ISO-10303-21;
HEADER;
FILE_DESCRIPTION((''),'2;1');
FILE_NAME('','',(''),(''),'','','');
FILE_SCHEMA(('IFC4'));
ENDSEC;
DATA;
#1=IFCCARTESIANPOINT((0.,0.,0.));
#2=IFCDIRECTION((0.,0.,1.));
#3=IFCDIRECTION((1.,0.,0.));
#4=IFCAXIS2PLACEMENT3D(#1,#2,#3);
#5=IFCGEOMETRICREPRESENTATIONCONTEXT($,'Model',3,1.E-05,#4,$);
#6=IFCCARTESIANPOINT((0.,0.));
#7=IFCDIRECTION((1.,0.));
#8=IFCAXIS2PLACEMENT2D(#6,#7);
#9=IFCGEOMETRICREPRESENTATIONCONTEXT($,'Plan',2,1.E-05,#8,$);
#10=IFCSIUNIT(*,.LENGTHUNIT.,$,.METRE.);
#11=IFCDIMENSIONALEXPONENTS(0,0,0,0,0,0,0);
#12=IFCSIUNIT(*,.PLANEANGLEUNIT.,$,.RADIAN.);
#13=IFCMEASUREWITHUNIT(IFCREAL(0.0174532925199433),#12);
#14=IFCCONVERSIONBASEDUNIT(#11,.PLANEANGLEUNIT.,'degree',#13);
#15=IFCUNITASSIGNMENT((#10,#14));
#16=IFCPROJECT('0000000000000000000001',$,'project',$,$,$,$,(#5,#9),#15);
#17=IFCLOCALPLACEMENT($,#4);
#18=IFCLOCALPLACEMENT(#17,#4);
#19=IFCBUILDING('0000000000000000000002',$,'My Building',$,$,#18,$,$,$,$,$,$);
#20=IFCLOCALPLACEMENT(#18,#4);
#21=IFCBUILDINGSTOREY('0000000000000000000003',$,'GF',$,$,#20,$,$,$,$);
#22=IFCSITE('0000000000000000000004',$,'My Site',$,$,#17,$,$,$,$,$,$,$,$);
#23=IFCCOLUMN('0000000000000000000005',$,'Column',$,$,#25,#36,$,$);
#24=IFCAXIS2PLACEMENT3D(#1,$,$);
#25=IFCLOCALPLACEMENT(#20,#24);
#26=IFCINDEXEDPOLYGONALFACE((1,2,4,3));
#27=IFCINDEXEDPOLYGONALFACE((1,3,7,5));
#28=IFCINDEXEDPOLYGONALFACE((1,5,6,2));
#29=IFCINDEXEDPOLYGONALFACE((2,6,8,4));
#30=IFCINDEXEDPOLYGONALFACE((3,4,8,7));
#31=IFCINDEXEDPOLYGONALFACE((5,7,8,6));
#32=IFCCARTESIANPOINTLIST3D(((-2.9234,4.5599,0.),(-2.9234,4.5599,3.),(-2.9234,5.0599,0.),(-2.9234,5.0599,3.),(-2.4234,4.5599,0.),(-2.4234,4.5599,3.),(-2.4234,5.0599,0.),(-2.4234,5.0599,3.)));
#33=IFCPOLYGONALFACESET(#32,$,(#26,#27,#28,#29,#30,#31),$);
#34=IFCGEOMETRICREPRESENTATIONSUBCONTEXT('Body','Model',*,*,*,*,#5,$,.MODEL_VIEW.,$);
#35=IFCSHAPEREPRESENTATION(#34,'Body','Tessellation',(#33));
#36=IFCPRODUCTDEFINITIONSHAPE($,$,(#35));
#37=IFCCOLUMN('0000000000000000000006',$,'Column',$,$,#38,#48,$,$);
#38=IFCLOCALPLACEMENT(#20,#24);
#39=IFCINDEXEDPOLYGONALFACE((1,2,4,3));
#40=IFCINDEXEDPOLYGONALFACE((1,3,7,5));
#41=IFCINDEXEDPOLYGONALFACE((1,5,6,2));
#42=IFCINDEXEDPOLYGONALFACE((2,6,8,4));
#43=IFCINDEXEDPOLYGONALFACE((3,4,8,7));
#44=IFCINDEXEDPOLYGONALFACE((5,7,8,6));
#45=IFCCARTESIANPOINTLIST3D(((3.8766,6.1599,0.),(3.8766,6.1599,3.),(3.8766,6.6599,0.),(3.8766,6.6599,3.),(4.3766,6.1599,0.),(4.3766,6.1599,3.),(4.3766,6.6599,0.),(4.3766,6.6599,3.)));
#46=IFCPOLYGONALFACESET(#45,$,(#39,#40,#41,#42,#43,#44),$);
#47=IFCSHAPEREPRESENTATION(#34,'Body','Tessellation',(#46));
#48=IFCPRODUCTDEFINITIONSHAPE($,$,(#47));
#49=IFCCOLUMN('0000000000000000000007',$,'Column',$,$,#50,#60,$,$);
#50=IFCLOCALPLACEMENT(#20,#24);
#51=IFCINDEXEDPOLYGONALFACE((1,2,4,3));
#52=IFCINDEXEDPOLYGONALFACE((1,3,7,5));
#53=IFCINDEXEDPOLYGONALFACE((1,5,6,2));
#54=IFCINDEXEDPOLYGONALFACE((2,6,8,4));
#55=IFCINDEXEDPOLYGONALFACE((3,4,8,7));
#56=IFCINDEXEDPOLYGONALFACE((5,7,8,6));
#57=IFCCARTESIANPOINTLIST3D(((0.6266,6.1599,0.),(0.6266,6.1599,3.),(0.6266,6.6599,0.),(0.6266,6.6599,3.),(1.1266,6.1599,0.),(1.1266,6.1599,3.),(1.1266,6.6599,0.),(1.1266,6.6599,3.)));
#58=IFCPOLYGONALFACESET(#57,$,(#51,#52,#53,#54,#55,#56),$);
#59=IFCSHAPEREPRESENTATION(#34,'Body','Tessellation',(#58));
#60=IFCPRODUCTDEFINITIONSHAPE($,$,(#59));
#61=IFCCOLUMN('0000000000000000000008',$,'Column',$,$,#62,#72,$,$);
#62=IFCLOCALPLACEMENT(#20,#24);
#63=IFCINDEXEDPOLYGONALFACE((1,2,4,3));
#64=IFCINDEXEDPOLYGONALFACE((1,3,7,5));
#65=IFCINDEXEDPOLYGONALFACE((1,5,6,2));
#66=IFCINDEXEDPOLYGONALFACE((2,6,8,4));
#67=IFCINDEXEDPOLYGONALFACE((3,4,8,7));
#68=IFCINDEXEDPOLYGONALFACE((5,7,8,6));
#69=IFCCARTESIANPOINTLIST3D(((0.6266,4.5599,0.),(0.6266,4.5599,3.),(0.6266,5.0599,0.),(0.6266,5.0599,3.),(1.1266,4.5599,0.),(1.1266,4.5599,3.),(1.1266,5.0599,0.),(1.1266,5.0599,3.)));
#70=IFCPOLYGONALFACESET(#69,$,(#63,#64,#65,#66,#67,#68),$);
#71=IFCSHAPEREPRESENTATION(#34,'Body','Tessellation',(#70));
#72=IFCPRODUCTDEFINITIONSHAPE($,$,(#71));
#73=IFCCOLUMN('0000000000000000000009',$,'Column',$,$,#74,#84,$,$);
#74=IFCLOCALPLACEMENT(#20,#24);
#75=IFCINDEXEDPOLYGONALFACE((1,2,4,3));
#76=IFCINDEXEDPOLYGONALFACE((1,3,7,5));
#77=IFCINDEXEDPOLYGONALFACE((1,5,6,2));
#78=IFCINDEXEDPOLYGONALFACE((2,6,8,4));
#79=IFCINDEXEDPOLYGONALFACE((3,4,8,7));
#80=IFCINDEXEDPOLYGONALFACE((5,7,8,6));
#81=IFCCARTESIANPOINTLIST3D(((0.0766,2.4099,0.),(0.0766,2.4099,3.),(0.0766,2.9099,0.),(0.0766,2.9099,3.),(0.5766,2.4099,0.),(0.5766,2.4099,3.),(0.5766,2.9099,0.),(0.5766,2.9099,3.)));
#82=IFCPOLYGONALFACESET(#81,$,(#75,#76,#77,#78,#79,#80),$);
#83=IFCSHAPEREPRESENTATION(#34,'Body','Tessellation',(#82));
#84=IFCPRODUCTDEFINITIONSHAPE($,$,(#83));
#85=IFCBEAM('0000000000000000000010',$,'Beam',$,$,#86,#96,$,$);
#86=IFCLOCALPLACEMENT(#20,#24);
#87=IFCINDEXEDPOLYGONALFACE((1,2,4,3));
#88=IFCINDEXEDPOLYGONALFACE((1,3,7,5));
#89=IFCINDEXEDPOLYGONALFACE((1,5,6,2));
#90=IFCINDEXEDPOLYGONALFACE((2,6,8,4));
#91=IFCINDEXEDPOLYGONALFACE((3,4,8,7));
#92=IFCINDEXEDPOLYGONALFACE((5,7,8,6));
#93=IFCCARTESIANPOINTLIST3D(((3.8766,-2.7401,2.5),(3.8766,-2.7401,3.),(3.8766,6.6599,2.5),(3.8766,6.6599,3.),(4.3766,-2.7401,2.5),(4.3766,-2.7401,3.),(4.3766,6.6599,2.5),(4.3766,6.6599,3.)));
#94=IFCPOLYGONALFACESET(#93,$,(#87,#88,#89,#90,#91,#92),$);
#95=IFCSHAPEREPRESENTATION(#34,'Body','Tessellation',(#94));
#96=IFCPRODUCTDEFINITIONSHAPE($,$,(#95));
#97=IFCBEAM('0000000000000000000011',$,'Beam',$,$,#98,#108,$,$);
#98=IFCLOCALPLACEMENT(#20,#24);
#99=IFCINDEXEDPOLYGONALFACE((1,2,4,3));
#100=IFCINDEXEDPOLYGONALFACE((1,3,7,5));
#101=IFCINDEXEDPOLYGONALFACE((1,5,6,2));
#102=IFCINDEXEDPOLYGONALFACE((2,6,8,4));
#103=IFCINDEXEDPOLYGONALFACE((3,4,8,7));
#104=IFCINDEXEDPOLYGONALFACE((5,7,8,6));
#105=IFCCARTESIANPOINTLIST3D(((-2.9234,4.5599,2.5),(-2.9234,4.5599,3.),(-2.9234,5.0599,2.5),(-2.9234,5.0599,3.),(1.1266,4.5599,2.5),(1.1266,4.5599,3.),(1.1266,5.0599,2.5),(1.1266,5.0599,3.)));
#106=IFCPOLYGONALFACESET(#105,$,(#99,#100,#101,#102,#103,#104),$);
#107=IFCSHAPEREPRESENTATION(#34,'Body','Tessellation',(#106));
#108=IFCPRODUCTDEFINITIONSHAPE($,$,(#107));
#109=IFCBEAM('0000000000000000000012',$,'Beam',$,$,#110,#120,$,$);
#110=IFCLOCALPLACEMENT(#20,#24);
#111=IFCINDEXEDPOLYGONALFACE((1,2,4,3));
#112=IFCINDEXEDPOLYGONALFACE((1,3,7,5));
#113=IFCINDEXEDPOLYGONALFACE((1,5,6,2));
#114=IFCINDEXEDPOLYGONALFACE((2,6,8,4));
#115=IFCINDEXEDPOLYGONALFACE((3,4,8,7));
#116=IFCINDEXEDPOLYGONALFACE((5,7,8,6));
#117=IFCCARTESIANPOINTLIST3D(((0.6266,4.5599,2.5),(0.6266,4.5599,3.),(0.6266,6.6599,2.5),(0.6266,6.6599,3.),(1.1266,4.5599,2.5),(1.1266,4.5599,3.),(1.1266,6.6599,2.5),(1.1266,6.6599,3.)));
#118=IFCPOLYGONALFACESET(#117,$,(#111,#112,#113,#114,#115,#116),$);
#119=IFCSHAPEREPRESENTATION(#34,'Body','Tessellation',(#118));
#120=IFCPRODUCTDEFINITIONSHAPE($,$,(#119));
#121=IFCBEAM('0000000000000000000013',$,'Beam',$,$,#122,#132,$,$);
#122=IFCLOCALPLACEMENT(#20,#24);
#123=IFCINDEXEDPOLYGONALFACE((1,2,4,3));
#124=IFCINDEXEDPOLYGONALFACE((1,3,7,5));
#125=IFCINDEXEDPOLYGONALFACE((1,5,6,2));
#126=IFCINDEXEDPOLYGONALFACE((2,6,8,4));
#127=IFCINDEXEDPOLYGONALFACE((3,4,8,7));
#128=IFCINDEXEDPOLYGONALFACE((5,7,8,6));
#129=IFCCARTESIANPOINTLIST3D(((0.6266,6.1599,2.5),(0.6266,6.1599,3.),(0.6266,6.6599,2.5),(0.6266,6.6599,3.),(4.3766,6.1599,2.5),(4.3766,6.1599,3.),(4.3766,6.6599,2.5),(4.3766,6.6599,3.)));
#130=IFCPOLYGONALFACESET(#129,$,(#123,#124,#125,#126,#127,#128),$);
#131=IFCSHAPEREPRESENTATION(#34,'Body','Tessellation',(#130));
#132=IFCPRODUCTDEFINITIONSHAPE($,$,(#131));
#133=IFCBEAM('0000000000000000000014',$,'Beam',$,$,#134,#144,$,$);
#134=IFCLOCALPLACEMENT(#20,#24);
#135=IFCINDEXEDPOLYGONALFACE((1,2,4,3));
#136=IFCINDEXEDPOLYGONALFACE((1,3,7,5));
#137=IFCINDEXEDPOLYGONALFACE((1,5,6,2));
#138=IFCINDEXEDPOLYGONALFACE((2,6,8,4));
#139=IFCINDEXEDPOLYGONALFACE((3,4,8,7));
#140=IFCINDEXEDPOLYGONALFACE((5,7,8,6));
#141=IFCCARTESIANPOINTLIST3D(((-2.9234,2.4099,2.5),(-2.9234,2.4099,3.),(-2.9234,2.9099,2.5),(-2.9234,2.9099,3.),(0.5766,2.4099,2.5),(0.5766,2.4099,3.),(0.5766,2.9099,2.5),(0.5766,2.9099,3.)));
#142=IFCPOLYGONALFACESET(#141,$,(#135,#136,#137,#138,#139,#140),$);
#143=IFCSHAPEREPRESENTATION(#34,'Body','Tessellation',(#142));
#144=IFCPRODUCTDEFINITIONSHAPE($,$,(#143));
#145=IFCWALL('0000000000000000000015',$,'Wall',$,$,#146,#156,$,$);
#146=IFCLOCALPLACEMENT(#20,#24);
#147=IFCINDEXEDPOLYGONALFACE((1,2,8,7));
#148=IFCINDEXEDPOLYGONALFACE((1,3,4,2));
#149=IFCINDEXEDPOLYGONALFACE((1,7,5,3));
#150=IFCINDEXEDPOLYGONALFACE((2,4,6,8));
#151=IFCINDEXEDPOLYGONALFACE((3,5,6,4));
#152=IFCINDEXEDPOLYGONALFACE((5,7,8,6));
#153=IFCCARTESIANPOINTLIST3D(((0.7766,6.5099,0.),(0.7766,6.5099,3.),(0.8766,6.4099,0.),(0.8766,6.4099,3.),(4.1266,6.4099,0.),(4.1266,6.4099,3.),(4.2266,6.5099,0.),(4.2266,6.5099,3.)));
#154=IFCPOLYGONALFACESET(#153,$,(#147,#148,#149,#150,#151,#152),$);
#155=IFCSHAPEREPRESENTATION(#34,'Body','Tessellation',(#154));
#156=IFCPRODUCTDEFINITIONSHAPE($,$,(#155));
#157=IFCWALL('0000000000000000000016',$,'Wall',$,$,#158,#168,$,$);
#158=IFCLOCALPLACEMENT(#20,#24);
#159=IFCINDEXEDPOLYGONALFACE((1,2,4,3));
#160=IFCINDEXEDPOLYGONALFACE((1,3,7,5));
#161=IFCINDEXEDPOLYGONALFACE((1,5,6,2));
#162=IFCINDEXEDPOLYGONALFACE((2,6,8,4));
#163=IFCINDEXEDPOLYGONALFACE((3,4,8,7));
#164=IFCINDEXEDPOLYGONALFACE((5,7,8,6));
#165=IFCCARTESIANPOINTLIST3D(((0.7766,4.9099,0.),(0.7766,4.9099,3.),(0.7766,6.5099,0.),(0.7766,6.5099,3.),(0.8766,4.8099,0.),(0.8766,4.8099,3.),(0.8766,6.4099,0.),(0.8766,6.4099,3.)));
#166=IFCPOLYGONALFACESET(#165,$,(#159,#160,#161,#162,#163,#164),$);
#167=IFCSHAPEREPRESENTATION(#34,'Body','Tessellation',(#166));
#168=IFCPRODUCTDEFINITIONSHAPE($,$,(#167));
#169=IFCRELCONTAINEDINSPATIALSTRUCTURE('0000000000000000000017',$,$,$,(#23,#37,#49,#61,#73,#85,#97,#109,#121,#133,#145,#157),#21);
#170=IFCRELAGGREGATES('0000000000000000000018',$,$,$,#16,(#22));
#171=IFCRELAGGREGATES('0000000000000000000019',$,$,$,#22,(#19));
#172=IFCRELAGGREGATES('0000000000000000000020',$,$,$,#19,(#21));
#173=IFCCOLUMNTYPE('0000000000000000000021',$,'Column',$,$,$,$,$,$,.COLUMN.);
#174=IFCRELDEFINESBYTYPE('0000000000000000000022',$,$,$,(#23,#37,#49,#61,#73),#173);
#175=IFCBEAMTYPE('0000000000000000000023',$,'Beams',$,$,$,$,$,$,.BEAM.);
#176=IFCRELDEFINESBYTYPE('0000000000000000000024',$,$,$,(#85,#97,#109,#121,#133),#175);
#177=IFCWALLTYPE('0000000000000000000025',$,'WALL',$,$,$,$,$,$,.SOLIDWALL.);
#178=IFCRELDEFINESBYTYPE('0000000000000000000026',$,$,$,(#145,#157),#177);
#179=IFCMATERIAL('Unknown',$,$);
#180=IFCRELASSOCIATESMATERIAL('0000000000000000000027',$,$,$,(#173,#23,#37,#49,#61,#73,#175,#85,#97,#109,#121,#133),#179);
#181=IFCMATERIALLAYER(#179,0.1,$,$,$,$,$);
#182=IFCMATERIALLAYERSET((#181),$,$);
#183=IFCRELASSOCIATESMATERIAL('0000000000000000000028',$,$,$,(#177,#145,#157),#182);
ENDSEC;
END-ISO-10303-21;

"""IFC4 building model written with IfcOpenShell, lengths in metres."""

from ifc_helpers import new_model, entity, si_unit, converted_unit, frame, origin_with_axes, origin_2d_with_axis, place, context, subcontext, project, spatial, line, indexed_curve, rectangle, outline, extrude, material, layer, layer_set, layer_usage, material_profile, profile_set, profile_usage, type_object, element, save


model = new_model("IFC4")

# Units and contexts
model_context = context("Model", 3, precision=1e-05, world=origin_with_axes())
plan_context = context("Plan", 2, precision=1e-05, world=origin_2d_with_axis())
body_context_1 = subcontext(model_context, "Body", "Model", "MODEL_VIEW")
ifc_project = project(units=[si_unit("LENGTHUNIT", "METRE"), converted_unit("PLANEANGLEUNIT", "degree", entity("IfcReal", 0.0174532925199433), si_unit("PLANEANGLEUNIT", "RADIAN"), dimensions=[0, 0, 0, 0, 0, 0, 0])], contexts=[model_context, plan_context])

# Site, building, storey
site_placement = place(None, origin_with_axes())
site = spatial("IfcSite", under=ifc_project, at=site_placement, Name="My Site")
building_placement = place(site_placement, origin_with_axes())
building = spatial("IfcBuilding", under=site, at=building_placement, Name="My Building")
storey_placement = place(building_placement, origin_with_axes())
storey = spatial("IfcBuildingStorey", under=building, at=storey_placement, Name="GF")

# Columns
ifc_material = material(Name="Unknown")
ifc_material_profile_1 = material_profile(ifc_material, rectangle(XDim=0.5, YDim=0.5))
ifc_profile_set_1 = profile_set([ifc_material_profile_1])
ifc_profile_usage_1 = profile_usage(ifc_profile_set_1, cardinal=5)
column_type = type_object("IfcColumnType", Name="Column", PredefinedType="COLUMN", material=ifc_profile_set_1)
column_1_placement = place(storey_placement, frame((-2.6734, 4.8099, 0.0), z_axis=(0.0, 0.0, 1.0), x_axis=(1.0, 0.0, 0.0)))
element("IfcColumn", 1, at=column_1_placement, inside=storey, type_object=column_type, material=ifc_profile_usage_1, Name="Column", context=body_context_1, shape_type="SweptSolid", body=[
    extrude(rectangle(XDim=0.5, YDim=0.5), origin_with_axes(), (0.0, 0.0, 1.0), 3.0),
])
ifc_profile_usage_2 = profile_usage(ifc_profile_set_1, cardinal=5)
column_2_placement = place(storey_placement, frame((4.1266, 6.4099, 0.0), z_axis=(0.0, 0.0, 1.0), x_axis=(1.0, 0.0, 0.0)))
element("IfcColumn", 2, at=column_2_placement, inside=storey, type_object=column_type, material=ifc_profile_usage_2, Name="Column", context=body_context_1, shape_type="SweptSolid", body=[
    extrude(rectangle(XDim=0.5, YDim=0.5), origin_with_axes(), (0.0, 0.0, 1.0), 3.0),
])
ifc_profile_usage_3 = profile_usage(ifc_profile_set_1, cardinal=5)
column_3_placement = place(storey_placement, frame((0.8766, 6.4099, 0.0), z_axis=(0.0, 0.0, 1.0), x_axis=(1.0, 0.0, 0.0)))
element("IfcColumn", 3, at=column_3_placement, inside=storey, type_object=column_type, material=ifc_profile_usage_3, Name="Column", context=body_context_1, shape_type="SweptSolid", body=[
    extrude(rectangle(XDim=0.5, YDim=0.5), origin_with_axes(), (0.0, 0.0, 1.0), 3.0),
])
ifc_profile_usage_4 = profile_usage(ifc_profile_set_1, cardinal=5)
column_4_placement = place(storey_placement, frame((0.8766, 4.8099, 0.0), z_axis=(0.0, 0.0, 1.0), x_axis=(1.0, 0.0, 0.0)))
element("IfcColumn", 4, at=column_4_placement, inside=storey, type_object=column_type, material=ifc_profile_usage_4, Name="Column", context=body_context_1, shape_type="SweptSolid", body=[
    extrude(rectangle(XDim=0.5, YDim=0.5), origin_with_axes(), (0.0, 0.0, 1.0), 3.0),
])
ifc_profile_usage_5 = profile_usage(ifc_profile_set_1, cardinal=5)
column_5_placement = place(storey_placement, frame((0.3266, 2.6599, 0.0), z_axis=(0.0, 0.0, 1.0), x_axis=(1.0, 0.0, 0.0)))
element("IfcColumn", 5, at=column_5_placement, inside=storey, type_object=column_type, material=ifc_profile_usage_5, Name="Column", context=body_context_1, shape_type="SweptSolid", body=[
    extrude(rectangle(XDim=0.5, YDim=0.5), origin_with_axes(), (0.0, 0.0, 1.0), 3.0),
])

# Beams
ifc_material_profile_2 = material_profile(ifc_material, rectangle(XDim=0.5, YDim=0.5))
ifc_profile_set_2 = profile_set([ifc_material_profile_2])
ifc_profile_usage_6 = profile_usage(ifc_profile_set_2, cardinal=7)
beam_type = type_object("IfcBeamType", Name="Beams", PredefinedType="BEAM", material=ifc_profile_set_2)
beam_1_placement = place(storey_placement, frame((4.3766, 6.6599, 3.0), z_axis=(0.0, -1.0, 0.0), x_axis=(1.0, 0.0, 0.0)))
element("IfcBeam", 6, at=beam_1_placement, inside=storey, type_object=beam_type, material=ifc_profile_usage_6, Name="Beam", context=body_context_1, shape_type="SweptSolid", body=[
    extrude(rectangle(XDim=0.5, YDim=0.5), frame((-0.25, -0.25, 0.0), z_axis=(0.0, 0.0, 1.0), x_axis=(1.0, 0.0, 0.0)), (0.0, 0.0, 1.0), 9.4),
])
ifc_profile_usage_7 = profile_usage(ifc_profile_set_2, cardinal=7)
beam_2_placement = place(storey_placement, frame((-2.9234, 5.0599, 3.0), z_axis=(1.0, 0.0, 0.0), x_axis=(0.0, 1.0, 0.0)))
element("IfcBeam", 7, at=beam_2_placement, inside=storey, type_object=beam_type, material=ifc_profile_usage_7, Name="Beam", context=body_context_1, shape_type="SweptSolid", body=[
    extrude(rectangle(XDim=0.5, YDim=0.5), frame((-0.25, -0.25, 0.0), z_axis=(0.0, 0.0, 1.0), x_axis=(1.0, 0.0, 0.0)), (0.0, 0.0, 1.0), 4.05),
])
ifc_profile_usage_8 = profile_usage(ifc_profile_set_2, cardinal=7)
beam_3_placement = place(storey_placement, frame((0.6266, 4.5599, 3.0), z_axis=(0.0, 1.0, 0.0), x_axis=(-1.0, 0.0, 0.0)))
element("IfcBeam", 8, at=beam_3_placement, inside=storey, type_object=beam_type, material=ifc_profile_usage_8, Name="Beam", context=body_context_1, shape_type="SweptSolid", body=[
    extrude(rectangle(XDim=0.5, YDim=0.5), frame((-0.25, -0.25, 0.0), z_axis=(0.0, 0.0, 1.0), x_axis=(1.0, 0.0, 0.0)), (0.0, 0.0, 1.0), 2.1),
])
ifc_profile_usage_9 = profile_usage(ifc_profile_set_2, cardinal=7)
beam_4_placement = place(storey_placement, frame((0.6266, 6.6599, 3.0), z_axis=(1.0, 0.0, 0.0), x_axis=(0.0, 1.0, 0.0)))
element("IfcBeam", 9, at=beam_4_placement, inside=storey, type_object=beam_type, material=ifc_profile_usage_9, Name="Beam", context=body_context_1, shape_type="SweptSolid", body=[
    extrude(rectangle(XDim=0.5, YDim=0.5), frame((-0.25, -0.25, 0.0), z_axis=(0.0, 0.0, 1.0), x_axis=(1.0, 0.0, 0.0)), (0.0, 0.0, 1.0), 3.75),
])
ifc_profile_usage_10 = profile_usage(ifc_profile_set_2, cardinal=5)
beam_5_placement = place(storey_placement, frame((0.5766, 2.6599, 2.75), z_axis=(-1.0, 0.0, 0.0), x_axis=(0.0, -1.0, 0.0)))
element("IfcBeam", 10, at=beam_5_placement, inside=storey, type_object=beam_type, material=ifc_profile_usage_10, Name="Beam", context=body_context_1, shape_type="SweptSolid", body=[
    extrude(rectangle(XDim=0.5, YDim=0.5), origin_with_axes(), (0.0, 0.0, 1.0), 3.5),
])

# Walls
ifc_layer = layer(ifc_material, 0.1)
ifc_layer_set = layer_set([ifc_layer])
ifc_layer_usage_1 = layer_usage(ifc_layer_set, "AXIS2", "POSITIVE", 0.0)
wall_type = type_object("IfcWallType", Name="WALL", PredefinedType="SOLIDWALL", material=ifc_layer_set)
wall_1_placement = place(storey_placement, frame((4.2266, 6.5099, 0.0), z_axis=(0.0, 0.0, 1.0), x_axis=(-1.0, 0.0, 0.0)))
element("IfcWall", 11, at=wall_1_placement, inside=storey, type_object=wall_type, material=ifc_layer_usage_1, Name="Wall", context=body_context_1, shape_type="SweptSolid", body=[
    extrude(outline(indexed_curve([(0.0, 0.0), (0.1, 0.1), (3.35, 0.1), (3.45, 0.0)], segments=[line(1, 2, 3, 4, 1)])), origin_with_axes(), (0.0, 0.0, 1.0), 3.0),
])
ifc_layer_usage_2 = layer_usage(ifc_layer_set, "AXIS2", "POSITIVE", 0.0)
wall_2_placement = place(storey_placement, frame((0.7766, 6.5099, 0.0), z_axis=(0.0, 0.0, 1.0), x_axis=(0.0, -1.0, 0.0)))
element("IfcWall", 12, at=wall_2_placement, inside=storey, type_object=wall_type, material=ifc_layer_usage_2, Name="Wall", context=body_context_1, shape_type="SweptSolid", body=[
    extrude(outline(indexed_curve([(0.0, 0.0), (0.1, 0.1), (1.7, 0.1), (1.6, 0.0)], segments=[line(1, 2, 3, 4, 1)])), origin_with_axes(), (0.0, 0.0, 1.0), 3.0),
])

save(model, "model.ifc")
